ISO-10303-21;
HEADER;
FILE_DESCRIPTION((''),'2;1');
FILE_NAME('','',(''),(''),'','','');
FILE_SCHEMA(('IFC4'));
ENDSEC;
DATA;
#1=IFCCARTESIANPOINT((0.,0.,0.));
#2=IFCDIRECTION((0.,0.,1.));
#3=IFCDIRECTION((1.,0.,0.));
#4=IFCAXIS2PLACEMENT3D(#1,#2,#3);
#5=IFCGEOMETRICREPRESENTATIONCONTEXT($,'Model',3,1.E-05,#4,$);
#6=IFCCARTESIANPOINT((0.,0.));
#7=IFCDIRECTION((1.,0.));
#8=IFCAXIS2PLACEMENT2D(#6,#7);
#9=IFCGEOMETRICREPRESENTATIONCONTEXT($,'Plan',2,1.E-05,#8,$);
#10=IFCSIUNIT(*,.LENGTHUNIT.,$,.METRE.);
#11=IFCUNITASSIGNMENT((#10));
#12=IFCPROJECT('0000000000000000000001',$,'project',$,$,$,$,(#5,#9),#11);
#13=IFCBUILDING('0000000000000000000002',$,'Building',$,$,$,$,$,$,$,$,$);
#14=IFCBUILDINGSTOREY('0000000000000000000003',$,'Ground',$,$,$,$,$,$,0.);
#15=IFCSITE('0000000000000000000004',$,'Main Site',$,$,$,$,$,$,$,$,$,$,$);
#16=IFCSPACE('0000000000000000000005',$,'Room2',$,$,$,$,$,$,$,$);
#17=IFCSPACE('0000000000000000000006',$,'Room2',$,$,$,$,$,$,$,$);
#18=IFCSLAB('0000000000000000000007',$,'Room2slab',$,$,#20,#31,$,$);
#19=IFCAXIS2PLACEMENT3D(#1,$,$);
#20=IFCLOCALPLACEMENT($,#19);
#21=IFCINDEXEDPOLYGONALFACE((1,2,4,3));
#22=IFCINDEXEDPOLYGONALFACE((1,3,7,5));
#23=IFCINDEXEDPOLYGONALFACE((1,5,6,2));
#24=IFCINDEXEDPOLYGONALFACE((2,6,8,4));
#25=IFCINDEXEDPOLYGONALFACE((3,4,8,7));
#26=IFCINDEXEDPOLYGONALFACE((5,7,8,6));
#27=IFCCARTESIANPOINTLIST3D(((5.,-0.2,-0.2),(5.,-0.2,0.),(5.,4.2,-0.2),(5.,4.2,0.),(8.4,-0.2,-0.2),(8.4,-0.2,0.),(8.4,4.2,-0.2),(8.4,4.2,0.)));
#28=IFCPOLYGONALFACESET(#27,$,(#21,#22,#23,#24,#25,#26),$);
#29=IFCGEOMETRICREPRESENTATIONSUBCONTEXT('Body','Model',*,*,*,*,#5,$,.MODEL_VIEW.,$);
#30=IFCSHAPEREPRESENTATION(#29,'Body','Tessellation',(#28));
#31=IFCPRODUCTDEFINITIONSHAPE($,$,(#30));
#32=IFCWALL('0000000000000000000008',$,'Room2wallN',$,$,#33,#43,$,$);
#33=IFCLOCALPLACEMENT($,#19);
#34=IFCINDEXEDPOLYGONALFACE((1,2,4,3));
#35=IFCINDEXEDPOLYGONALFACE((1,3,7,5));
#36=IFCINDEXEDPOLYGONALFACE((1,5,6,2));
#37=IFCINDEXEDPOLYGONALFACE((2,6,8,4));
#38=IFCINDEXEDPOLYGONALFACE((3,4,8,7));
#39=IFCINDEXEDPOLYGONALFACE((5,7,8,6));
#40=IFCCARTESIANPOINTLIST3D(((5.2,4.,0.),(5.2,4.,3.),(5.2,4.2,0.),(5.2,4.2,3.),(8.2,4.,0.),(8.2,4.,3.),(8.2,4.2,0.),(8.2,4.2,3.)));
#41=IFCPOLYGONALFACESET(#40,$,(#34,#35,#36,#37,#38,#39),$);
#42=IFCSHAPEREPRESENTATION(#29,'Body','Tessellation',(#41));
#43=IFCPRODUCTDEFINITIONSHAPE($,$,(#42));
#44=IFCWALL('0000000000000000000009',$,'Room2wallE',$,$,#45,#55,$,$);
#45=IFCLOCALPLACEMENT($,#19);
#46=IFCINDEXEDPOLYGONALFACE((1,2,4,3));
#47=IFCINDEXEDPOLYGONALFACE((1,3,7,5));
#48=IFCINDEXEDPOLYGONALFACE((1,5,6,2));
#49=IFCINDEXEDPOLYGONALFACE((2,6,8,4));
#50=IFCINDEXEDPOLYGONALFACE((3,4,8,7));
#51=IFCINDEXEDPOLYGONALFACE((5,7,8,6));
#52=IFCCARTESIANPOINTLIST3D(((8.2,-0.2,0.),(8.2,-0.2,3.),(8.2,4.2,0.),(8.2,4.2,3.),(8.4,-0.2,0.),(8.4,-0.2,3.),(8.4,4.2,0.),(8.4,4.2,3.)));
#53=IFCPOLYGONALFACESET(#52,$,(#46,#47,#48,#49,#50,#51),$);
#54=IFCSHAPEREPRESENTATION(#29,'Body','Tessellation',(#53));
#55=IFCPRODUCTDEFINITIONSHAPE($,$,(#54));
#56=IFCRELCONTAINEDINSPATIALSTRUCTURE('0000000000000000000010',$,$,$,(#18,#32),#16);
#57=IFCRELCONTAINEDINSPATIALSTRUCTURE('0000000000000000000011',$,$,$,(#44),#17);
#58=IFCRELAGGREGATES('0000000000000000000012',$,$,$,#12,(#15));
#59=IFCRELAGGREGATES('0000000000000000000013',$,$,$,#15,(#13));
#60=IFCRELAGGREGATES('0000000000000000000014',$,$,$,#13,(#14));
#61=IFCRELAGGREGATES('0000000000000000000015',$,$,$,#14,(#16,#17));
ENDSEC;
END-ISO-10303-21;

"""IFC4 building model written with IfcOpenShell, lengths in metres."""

from ifc_helpers import new_model, si_unit, frame, origin_with_axes, origin_2d_with_axis, place, context, subcontext, project, spatial, indexed_curve, rectangle, outline, extrude, element, save


model = new_model("IFC4")

# Units and contexts
model_context = context("Model", 3, precision=1e-05, world=origin_with_axes())
plan_context = context("Plan", 2, precision=1e-05, world=origin_2d_with_axis())
body_context = subcontext(model_context, "Body", "Model", "MODEL_VIEW")
ifc_project = project(units=[si_unit("LENGTHUNIT", "METRE")], contexts=[model_context, plan_context])

# Site, building, storey, space
site = spatial("IfcSite", under=ifc_project, Name="Main Site")
building = spatial("IfcBuilding", under=site, Name="Building")
storey = spatial("IfcBuildingStorey", under=building, Name="Ground", Elevation=0.0)
space_1 = spatial("IfcSpace", under=storey, Name="Room2")

# Slab
slab_1_placement = place(None, frame((6.7, 2.0, -0.2), z_axis=(0.0, 0.0, 1.0), x_axis=(1.0, 0.0, 0.0)))
element("IfcSlab", 1, at=slab_1_placement, inside=space_1, Name="Room2slab", context=body_context, shape_type="SweptSolid", body=[
    extrude(rectangle(XDim=3.4, YDim=4.4), origin_with_axes(), (0.0, 0.0, 1.0), 0.2),
])

# Shared definitions
space_2 = spatial("IfcSpace", under=storey, Name="Room2")

# Walls
wall_1_placement = place(None, frame((5.2, 4.0, 0.0), z_axis=(0.0, 0.0, 1.0), x_axis=(1.0, 0.0, 0.0)))
element("IfcWall", 2, at=wall_1_placement, inside=space_1, Name="Room2wallN", context=body_context, shape_type="SweptSolid", body=[
    extrude(outline(indexed_curve([(0.0, 0.0), (0.0, 0.2), (3.0, 0.2), (3.0, 0.0), (0.0, 0.0)], self_intersect=False)), origin_with_axes(), (0.0, 0.0, 1.0), 3.0),
])
wall_2_placement = place(None, frame((8.4, -0.2, 0.0), z_axis=(0.0, 0.0, 1.0), x_axis=(0.0, 1.0, 0.0)))
element("IfcWall", 3, at=wall_2_placement, inside=space_2, Name="Room2wallE", context=body_context, shape_type="SweptSolid", body=[
    extrude(outline(indexed_curve([(0.0, 0.0), (0.0, 0.2), (4.4, 0.2), (4.4, 0.0), (0.0, 0.0)], self_intersect=False)), origin_with_axes(), (0.0, 0.0, 1.0), 3.0),
])

save(model, "model.ifc")
